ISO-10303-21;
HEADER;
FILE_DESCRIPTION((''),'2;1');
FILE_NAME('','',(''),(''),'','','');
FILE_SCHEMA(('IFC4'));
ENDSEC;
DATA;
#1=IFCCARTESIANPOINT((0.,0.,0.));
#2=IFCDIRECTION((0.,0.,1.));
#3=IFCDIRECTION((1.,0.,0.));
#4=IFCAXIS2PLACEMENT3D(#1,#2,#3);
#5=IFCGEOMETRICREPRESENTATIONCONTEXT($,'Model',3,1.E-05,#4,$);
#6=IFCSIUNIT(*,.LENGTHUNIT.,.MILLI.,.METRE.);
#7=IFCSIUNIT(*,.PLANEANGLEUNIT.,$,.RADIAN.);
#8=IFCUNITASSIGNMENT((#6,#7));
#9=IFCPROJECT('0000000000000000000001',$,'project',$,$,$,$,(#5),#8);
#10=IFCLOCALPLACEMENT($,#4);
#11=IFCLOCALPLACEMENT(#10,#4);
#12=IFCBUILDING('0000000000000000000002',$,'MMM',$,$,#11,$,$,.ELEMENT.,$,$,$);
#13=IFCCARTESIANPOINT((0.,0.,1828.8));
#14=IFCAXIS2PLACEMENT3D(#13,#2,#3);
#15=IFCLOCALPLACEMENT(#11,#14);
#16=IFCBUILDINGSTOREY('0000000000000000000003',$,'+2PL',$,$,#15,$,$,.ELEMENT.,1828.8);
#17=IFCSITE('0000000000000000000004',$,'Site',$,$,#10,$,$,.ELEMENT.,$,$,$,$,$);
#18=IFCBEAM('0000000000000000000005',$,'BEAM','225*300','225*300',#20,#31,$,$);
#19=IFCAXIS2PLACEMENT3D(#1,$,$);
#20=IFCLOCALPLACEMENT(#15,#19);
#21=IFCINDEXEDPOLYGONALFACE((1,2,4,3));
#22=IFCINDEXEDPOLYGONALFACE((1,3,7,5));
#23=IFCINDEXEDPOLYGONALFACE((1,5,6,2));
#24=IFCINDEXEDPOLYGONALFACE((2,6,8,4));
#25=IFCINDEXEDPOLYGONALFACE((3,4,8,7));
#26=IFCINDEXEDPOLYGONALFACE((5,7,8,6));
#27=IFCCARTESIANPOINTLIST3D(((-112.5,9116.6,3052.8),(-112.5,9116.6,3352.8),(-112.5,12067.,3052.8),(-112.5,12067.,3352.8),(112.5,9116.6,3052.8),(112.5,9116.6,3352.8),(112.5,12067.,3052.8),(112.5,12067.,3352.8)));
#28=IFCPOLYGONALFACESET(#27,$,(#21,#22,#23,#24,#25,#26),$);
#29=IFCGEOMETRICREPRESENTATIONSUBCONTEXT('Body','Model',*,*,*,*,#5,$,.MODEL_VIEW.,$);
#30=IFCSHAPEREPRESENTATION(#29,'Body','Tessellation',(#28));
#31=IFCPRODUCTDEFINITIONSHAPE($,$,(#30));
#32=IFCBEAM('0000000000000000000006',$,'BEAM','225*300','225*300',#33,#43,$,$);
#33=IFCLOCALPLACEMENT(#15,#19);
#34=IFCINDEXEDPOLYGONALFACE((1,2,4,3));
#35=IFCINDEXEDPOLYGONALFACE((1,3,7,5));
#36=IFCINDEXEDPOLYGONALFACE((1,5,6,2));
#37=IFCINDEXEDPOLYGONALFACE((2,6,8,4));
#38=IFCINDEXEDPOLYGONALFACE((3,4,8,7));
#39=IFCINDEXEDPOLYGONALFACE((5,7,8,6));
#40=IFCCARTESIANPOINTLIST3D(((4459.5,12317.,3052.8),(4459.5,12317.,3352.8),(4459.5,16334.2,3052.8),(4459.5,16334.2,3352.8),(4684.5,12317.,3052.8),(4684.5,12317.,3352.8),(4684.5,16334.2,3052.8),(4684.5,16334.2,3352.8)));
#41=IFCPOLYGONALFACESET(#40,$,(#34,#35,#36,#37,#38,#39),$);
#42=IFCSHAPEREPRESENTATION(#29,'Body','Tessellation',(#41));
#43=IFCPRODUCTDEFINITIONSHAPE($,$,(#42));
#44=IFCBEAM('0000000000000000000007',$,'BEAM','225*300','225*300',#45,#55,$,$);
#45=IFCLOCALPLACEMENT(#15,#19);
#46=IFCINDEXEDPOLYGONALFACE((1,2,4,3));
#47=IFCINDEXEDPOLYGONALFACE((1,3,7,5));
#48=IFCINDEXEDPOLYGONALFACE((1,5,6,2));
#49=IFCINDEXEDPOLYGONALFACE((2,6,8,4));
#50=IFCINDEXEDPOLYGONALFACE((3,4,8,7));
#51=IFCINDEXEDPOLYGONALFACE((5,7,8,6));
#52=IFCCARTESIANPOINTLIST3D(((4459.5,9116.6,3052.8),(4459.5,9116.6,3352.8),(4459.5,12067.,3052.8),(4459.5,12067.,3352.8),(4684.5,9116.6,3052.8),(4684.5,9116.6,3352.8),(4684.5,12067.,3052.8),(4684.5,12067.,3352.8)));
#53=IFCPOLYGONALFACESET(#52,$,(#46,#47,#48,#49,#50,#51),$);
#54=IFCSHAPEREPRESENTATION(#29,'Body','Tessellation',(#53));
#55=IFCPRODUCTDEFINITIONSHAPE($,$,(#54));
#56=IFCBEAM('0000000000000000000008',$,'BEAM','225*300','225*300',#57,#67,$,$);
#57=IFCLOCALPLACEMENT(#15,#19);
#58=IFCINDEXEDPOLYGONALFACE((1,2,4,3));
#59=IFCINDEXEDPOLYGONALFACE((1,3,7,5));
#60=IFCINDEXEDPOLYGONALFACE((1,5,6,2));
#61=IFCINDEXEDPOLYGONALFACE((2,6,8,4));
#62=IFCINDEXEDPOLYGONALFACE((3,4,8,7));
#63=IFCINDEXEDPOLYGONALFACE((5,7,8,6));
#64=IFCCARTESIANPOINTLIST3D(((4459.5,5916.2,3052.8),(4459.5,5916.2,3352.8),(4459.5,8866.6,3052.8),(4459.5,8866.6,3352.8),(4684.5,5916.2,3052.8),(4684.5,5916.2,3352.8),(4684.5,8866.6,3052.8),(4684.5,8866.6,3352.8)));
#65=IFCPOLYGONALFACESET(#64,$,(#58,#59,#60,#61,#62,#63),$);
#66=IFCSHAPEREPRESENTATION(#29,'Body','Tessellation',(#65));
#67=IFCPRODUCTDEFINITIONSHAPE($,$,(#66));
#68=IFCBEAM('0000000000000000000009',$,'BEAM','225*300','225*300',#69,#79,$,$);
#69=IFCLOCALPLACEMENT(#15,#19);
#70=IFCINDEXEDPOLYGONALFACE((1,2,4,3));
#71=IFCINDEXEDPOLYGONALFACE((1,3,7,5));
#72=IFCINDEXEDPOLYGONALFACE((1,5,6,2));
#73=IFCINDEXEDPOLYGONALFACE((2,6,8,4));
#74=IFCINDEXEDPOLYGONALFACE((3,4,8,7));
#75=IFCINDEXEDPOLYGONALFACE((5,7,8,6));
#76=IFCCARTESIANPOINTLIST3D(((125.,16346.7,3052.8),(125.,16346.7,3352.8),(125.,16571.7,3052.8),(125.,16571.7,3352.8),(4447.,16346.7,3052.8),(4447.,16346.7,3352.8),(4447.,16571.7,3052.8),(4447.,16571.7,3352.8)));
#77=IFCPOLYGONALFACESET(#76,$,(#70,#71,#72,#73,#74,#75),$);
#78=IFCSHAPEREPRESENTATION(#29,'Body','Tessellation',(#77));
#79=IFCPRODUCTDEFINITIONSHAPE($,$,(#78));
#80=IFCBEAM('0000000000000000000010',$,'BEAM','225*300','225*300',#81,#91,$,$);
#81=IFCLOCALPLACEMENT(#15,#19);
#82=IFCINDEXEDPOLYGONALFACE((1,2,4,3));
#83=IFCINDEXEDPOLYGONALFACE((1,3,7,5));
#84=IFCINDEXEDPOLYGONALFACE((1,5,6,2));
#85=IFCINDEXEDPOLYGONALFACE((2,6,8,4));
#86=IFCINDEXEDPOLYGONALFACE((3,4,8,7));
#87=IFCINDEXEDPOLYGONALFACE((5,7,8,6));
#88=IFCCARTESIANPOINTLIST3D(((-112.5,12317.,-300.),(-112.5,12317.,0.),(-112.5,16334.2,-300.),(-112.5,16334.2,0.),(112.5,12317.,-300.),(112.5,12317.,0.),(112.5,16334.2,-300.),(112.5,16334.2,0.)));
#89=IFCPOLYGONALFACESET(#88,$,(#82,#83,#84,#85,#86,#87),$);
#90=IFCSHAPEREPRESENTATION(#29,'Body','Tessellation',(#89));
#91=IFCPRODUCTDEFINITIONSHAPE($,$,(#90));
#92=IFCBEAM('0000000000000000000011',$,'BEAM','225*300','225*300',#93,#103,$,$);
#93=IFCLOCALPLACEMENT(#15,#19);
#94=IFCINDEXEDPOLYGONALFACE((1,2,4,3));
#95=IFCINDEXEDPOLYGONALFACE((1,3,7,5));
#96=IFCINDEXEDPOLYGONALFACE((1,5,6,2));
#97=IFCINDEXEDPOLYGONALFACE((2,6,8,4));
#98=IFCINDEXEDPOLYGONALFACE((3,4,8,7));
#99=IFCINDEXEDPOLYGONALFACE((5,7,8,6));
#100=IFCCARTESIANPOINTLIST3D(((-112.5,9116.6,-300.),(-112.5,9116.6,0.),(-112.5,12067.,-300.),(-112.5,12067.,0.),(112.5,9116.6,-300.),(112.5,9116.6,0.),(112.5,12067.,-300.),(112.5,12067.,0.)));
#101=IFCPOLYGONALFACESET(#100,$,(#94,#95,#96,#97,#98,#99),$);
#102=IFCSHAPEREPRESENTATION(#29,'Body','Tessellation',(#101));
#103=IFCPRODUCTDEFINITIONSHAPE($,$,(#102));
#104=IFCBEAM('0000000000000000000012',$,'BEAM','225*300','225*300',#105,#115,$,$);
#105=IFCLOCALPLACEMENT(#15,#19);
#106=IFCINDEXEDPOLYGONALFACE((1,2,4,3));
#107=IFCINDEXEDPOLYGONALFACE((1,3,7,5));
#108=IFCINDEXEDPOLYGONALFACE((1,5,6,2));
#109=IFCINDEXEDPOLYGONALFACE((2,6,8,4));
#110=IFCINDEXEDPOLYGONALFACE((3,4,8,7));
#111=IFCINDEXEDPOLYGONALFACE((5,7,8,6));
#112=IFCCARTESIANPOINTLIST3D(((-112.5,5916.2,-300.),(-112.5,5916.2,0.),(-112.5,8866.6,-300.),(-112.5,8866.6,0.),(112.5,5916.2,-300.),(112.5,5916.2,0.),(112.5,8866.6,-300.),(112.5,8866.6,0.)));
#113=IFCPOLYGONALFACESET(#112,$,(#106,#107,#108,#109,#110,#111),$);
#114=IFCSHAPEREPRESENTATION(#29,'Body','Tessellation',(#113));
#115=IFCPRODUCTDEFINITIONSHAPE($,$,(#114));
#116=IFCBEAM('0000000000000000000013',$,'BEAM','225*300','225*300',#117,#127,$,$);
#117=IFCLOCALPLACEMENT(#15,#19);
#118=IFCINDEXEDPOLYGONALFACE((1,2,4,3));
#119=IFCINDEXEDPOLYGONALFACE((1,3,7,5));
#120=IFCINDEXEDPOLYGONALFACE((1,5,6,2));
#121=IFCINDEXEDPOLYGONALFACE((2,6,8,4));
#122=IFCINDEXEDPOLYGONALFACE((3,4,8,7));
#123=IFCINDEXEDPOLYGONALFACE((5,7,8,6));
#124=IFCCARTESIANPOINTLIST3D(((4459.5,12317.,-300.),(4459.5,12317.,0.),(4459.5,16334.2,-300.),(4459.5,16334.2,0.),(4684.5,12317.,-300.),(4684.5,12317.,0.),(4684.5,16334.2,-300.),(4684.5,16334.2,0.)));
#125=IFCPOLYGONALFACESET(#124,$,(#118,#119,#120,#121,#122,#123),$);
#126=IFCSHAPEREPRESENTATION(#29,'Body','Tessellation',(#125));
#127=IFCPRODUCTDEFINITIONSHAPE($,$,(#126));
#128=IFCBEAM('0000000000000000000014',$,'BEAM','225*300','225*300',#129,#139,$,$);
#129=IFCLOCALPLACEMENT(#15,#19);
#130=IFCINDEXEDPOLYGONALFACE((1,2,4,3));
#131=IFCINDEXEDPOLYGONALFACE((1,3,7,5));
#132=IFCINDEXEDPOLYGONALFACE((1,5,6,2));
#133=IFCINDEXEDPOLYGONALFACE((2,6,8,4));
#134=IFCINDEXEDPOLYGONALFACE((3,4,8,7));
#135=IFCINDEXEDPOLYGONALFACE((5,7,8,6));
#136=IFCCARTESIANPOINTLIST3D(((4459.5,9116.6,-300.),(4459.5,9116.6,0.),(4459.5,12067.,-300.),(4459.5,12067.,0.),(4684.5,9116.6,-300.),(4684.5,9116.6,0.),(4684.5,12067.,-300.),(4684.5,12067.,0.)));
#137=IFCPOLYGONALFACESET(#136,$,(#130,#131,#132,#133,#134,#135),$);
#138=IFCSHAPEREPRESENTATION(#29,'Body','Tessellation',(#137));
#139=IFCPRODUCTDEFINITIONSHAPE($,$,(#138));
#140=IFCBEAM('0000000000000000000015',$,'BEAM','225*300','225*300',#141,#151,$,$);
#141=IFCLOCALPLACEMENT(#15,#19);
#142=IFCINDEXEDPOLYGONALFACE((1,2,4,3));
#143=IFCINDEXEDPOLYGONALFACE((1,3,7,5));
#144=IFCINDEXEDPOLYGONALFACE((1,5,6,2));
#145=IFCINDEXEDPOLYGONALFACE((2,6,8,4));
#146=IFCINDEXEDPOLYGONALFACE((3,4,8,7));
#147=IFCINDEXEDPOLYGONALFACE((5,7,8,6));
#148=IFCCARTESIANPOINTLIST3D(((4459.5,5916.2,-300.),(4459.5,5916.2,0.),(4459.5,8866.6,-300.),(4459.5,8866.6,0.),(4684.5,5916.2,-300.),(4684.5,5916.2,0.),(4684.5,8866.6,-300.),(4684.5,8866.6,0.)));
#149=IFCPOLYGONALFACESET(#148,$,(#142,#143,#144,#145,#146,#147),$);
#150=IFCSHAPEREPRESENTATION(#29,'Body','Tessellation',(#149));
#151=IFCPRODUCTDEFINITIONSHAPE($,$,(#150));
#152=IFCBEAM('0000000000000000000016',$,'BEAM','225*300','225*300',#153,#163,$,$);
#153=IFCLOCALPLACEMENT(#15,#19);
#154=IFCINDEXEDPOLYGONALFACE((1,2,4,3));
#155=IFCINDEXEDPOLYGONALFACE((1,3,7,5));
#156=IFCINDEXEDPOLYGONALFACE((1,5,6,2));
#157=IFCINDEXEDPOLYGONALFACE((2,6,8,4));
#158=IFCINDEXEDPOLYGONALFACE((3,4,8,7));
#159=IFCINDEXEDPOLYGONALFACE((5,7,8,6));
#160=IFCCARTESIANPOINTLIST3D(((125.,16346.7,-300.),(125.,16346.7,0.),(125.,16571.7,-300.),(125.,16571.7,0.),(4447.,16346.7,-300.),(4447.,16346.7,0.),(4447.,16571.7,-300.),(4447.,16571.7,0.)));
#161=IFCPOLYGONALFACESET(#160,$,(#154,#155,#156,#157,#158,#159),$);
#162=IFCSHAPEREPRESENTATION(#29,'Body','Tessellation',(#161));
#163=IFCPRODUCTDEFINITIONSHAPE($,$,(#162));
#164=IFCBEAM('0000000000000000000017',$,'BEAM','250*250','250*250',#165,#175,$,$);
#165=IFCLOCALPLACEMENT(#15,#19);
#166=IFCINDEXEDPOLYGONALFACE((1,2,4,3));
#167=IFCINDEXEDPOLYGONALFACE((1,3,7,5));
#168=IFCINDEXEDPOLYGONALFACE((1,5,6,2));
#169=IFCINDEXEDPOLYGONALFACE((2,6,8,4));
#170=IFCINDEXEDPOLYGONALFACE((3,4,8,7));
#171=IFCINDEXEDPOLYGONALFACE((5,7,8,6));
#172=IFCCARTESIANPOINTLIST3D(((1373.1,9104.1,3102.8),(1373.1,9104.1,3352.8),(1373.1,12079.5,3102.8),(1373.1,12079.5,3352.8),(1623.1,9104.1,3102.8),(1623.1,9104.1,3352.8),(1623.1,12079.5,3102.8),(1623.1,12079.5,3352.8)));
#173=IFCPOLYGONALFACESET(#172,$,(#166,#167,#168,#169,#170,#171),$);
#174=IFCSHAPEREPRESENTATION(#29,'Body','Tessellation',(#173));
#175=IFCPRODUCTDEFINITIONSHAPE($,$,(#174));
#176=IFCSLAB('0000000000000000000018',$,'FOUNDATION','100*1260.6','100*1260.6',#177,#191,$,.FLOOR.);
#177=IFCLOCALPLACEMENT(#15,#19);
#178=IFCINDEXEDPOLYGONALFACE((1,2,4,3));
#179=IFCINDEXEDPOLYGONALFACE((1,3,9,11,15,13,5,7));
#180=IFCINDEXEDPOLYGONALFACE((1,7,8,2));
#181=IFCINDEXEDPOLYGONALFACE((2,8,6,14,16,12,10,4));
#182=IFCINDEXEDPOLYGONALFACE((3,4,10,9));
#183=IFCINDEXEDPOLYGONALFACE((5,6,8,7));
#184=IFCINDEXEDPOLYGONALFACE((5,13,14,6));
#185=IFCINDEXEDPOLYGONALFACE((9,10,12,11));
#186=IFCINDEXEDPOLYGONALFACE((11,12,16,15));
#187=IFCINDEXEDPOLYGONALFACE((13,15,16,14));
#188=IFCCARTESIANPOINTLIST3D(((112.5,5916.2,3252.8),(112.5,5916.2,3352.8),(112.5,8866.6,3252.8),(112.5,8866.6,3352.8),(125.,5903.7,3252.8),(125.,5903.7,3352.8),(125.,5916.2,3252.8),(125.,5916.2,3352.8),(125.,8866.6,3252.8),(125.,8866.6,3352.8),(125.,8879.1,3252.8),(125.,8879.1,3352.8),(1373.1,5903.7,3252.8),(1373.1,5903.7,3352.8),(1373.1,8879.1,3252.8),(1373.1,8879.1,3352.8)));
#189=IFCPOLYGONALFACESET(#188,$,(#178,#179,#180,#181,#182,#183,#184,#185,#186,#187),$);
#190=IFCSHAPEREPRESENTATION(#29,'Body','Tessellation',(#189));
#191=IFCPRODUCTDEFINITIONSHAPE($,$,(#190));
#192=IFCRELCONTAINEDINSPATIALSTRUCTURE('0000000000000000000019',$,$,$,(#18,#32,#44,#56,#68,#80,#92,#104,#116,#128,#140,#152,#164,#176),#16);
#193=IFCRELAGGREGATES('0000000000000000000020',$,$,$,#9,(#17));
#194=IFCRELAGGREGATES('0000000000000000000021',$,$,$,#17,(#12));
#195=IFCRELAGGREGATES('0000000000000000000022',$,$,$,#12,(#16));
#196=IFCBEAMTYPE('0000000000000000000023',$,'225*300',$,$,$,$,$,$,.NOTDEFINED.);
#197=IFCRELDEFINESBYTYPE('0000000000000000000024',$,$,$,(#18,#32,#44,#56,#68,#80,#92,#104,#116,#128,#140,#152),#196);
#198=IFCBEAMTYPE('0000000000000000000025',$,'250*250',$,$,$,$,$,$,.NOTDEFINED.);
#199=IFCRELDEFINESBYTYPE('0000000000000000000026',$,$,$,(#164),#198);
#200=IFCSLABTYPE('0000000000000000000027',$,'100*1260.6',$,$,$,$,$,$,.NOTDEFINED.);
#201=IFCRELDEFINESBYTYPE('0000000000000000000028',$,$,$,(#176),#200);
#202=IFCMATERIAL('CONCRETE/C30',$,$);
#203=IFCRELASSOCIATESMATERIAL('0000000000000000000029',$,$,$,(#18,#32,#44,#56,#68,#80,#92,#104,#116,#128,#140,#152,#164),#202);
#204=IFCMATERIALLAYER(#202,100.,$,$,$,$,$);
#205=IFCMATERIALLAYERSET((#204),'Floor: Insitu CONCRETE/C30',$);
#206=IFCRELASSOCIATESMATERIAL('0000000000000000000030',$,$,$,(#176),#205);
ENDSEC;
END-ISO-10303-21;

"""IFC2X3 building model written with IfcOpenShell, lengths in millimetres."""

from ifc_helpers import new_model, si_unit, frame, origin_with_axes, origin_2d_with_axis, place, context, subcontext, project, spatial, polyline, rectangle, outline, extrude, material, layer, layer_set, layer_usage, type_object, element, save


model = new_model("IFC2X3")

# Units and contexts
model_context = context("Model", 3, precision=1e-05, world=origin_with_axes())
body_context = subcontext(model_context, "Body", "Model", "MODEL_VIEW")
ifc_project = project(units=[si_unit("LENGTHUNIT", "METRE", prefix="MILLI"), si_unit("PLANEANGLEUNIT", "RADIAN")], contexts=[model_context])

# Site, building, storey
site_placement = place(None, origin_with_axes())
site = spatial("IfcSite", under=ifc_project, at=site_placement, Name="Site", CompositionType="ELEMENT")
building_placement = place(site_placement, origin_with_axes())
building = spatial("IfcBuilding", under=site, at=building_placement, Name="MMM", CompositionType="ELEMENT")
storey_placement = place(building_placement, frame((0.0, 0.0, 1828.8), z_axis=(0.0, 0.0, 1.0), x_axis=(1.0, 0.0, 0.0)))
storey = spatial("IfcBuildingStorey", under=building, at=storey_placement, Name="+2PL", CompositionType="ELEMENT", Elevation=1828.8)

# Shared definitions
ifc_material = material(Name="CONCRETE/C30")

# Beams
beam_type_1 = type_object("IfcBeamType", Name="225*300", PredefinedType="NOTDEFINED")
beam_1_placement = place(storey_placement, frame((0.0, 9116.6, 3202.8), z_axis=(0.0, 0.0, 1.0), x_axis=(0.0, 1.0, 0.0)))
element("IfcBeam", 1, at=beam_1_placement, inside=storey, type_object=beam_type_1, material=ifc_material, Name="BEAM", Description="225*300", ObjectType="225*300", context=body_context, shape_type="SweptSolid", body=[
    extrude(rectangle(XDim=225.0, YDim=300.0, at=origin_2d_with_axis()), frame((2950.4, 0.0, 0.0), z_axis=(-1.0, 0.0, 0.0), x_axis=(0.0, -1.0, 0.0)), (0.0, 0.0, 1.0), 2950.4),
])
beam_2_placement = place(storey_placement, frame((4572.0, 12317.0, 3202.8), z_axis=(0.0, 0.0, 1.0), x_axis=(0.0, 1.0, 0.0)))
element("IfcBeam", 2, at=beam_2_placement, inside=storey, type_object=beam_type_1, material=ifc_material, Name="BEAM", Description="225*300", ObjectType="225*300", context=body_context, shape_type="SweptSolid", body=[
    extrude(rectangle(XDim=225.0, YDim=300.0, at=origin_2d_with_axis()), frame((4017.2, 0.0, 0.0), z_axis=(-1.0, 0.0, 0.0), x_axis=(0.0, -1.0, 0.0)), (0.0, 0.0, 1.0), 4017.2),
])
for number, where, z_axis, x_axis, name in (
    (3, (4572.0, 9116.6, 3202.8), (0.0, 0.0, 1.0), (0.0, 1.0, 0.0), "BEAM"),
    (4, (4572.0, 5916.2, 3202.8), (0.0, 0.0, 1.0), (0.0, 1.0, 0.0), "BEAM"),
):
    element("IfcBeam", number, at=place(storey_placement, frame(where, z_axis=z_axis, x_axis=x_axis)), inside=storey, type_object=beam_type_1, material=ifc_material, Name=name, Description="225*300", ObjectType="225*300", context=body_context, shape_type="SweptSolid", body=[
        extrude(rectangle(XDim=225.0, YDim=300.0, at=origin_2d_with_axis()), frame((2950.4, 0.0, 0.0), z_axis=(-1.0, 0.0, 0.0), x_axis=(0.0, -1.0, 0.0)), (0.0, 0.0, 1.0), 2950.4),
    ])
beam_3_placement = place(storey_placement, frame((125.0, 16459.2, 3202.8), z_axis=(0.0, 0.0, 1.0), x_axis=(1.0, 0.0, 0.0)))
element("IfcBeam", 5, at=beam_3_placement, inside=storey, type_object=beam_type_1, material=ifc_material, Name="BEAM", Description="225*300", ObjectType="225*300", context=body_context, shape_type="SweptSolid", body=[
    extrude(rectangle(XDim=225.0, YDim=300.0, at=origin_2d_with_axis()), frame((4322.0, 0.0, 0.0), z_axis=(-1.0, 0.0, 0.0), x_axis=(0.0, -1.0, 0.0)), (0.0, 0.0, 1.0), 4322.0),
])
beam_4_placement = place(storey_placement, frame((0.0, 12317.0, -150.0), z_axis=(0.0, 0.0, 1.0), x_axis=(0.0, 1.0, 0.0)))
element("IfcBeam", 6, at=beam_4_placement, inside=storey, type_object=beam_type_1, material=ifc_material, Name="BEAM", Description="225*300", ObjectType="225*300", context=body_context, shape_type="SweptSolid", body=[
    extrude(rectangle(XDim=225.0, YDim=300.0, at=origin_2d_with_axis()), frame((4017.2, 0.0, 0.0), z_axis=(-1.0, 0.0, 0.0), x_axis=(0.0, -1.0, 0.0)), (0.0, 0.0, 1.0), 4017.2),
])
for number, where, z_axis, x_axis, name in (
    (7, (0.0, 9116.6, -150.0), (0.0, 0.0, 1.0), (0.0, 1.0, 0.0), "BEAM"),
    (8, (0.0, 5916.2, -150.0), (0.0, 0.0, 1.0), (0.0, 1.0, 0.0), "BEAM"),
):
    element("IfcBeam", number, at=place(storey_placement, frame(where, z_axis=z_axis, x_axis=x_axis)), inside=storey, type_object=beam_type_1, material=ifc_material, Name=name, Description="225*300", ObjectType="225*300", context=body_context, shape_type="SweptSolid", body=[
        extrude(rectangle(XDim=225.0, YDim=300.0, at=origin_2d_with_axis()), frame((2950.4, 0.0, 0.0), z_axis=(-1.0, 0.0, 0.0), x_axis=(0.0, -1.0, 0.0)), (0.0, 0.0, 1.0), 2950.4),
    ])
beam_5_placement = place(storey_placement, frame((4572.0, 12317.0, -150.0), z_axis=(0.0, 0.0, 1.0), x_axis=(0.0, 1.0, 0.0)))
element("IfcBeam", 9, at=beam_5_placement, inside=storey, type_object=beam_type_1, material=ifc_material, Name="BEAM", Description="225*300", ObjectType="225*300", context=body_context, shape_type="SweptSolid", body=[
    extrude(rectangle(XDim=225.0, YDim=300.0, at=origin_2d_with_axis()), frame((4017.2, 0.0, 0.0), z_axis=(-1.0, 0.0, 0.0), x_axis=(0.0, -1.0, 0.0)), (0.0, 0.0, 1.0), 4017.2),
])
for number, where, z_axis, x_axis, name in (
    (10, (4572.0, 9116.6, -150.0), (0.0, 0.0, 1.0), (0.0, 1.0, 0.0), "BEAM"),
    (11, (4572.0, 5916.2, -150.0), (0.0, 0.0, 1.0), (0.0, 1.0, 0.0), "BEAM"),
):
    element("IfcBeam", number, at=place(storey_placement, frame(where, z_axis=z_axis, x_axis=x_axis)), inside=storey, type_object=beam_type_1, material=ifc_material, Name=name, Description="225*300", ObjectType="225*300", context=body_context, shape_type="SweptSolid", body=[
        extrude(rectangle(XDim=225.0, YDim=300.0, at=origin_2d_with_axis()), frame((2950.4, 0.0, 0.0), z_axis=(-1.0, 0.0, 0.0), x_axis=(0.0, -1.0, 0.0)), (0.0, 0.0, 1.0), 2950.4),
    ])
beam_6_placement = place(storey_placement, frame((125.0, 16459.2, -150.0), z_axis=(0.0, 0.0, 1.0), x_axis=(1.0, 0.0, 0.0)))
element("IfcBeam", 12, at=beam_6_placement, inside=storey, type_object=beam_type_1, material=ifc_material, Name="BEAM", Description="225*300", ObjectType="225*300", context=body_context, shape_type="SweptSolid", body=[
    extrude(rectangle(XDim=225.0, YDim=300.0, at=origin_2d_with_axis()), frame((4322.0, 0.0, 0.0), z_axis=(-1.0, 0.0, 0.0), x_axis=(0.0, -1.0, 0.0)), (0.0, 0.0, 1.0), 4322.0),
])
beam_type_2 = type_object("IfcBeamType", Name="250*250", PredefinedType="NOTDEFINED")
beam_7_placement = place(storey_placement, frame((1498.1, 9104.1, 3227.8), z_axis=(0.0, 0.0, 1.0), x_axis=(0.0, 1.0, 0.0)))
element("IfcBeam", 13, at=beam_7_placement, inside=storey, type_object=beam_type_2, material=ifc_material, Name="BEAM", Description="250*250", ObjectType="250*250", context=body_context, shape_type="SweptSolid", body=[
    extrude(rectangle(XDim=250.0, YDim=250.0, at=origin_2d_with_axis()), frame((2975.4, 0.0, 0.0), z_axis=(-1.0, 0.0, 0.0), x_axis=(0.0, -1.0, 0.0)), (0.0, 0.0, 1.0), 2975.4),
])

# Slab
ifc_layer = layer(ifc_material, 100.0)
ifc_layer_set = layer_set([ifc_layer], Name="Floor: Insitu CONCRETE/C30")
ifc_layer_usage_1 = layer_usage(ifc_layer_set, "AXIS3", "POSITIVE", -50.0)
slab_type_1 = type_object("IfcSlabType", Name="100*1260.6", PredefinedType="NOTDEFINED")
slab_1_placement = place(storey_placement, frame((125.0, 8866.6, 3302.8), z_axis=(0.0, 0.0, 1.0), x_axis=(-1.0, 0.0, 0.0)))
element("IfcSlab", 14, at=slab_1_placement, inside=storey, type_object=slab_type_1, material=ifc_layer_usage_1, Name="FOUNDATION", Description="100*1260.6", ObjectType="100*1260.6", PredefinedType="FLOOR", context=body_context, shape_type="SweptSolid", body=[
    extrude(outline(polyline([(0.0, 0.0), (12.5, 0.0), (12.5, 2950.4), (0.0, 2950.4), (0.0, 2962.9), (-1248.1, 2962.9), (-1248.1, -12.5), (0.0, -12.5), (0.0, 0.0)])), frame((0.0, 0.0, -50.0), z_axis=(0.0, 0.0, 1.0), x_axis=(1.0, 0.0, 0.0)), (0.0, 0.0, 1.0), 100.0),
])

save(model, "model.ifc")
